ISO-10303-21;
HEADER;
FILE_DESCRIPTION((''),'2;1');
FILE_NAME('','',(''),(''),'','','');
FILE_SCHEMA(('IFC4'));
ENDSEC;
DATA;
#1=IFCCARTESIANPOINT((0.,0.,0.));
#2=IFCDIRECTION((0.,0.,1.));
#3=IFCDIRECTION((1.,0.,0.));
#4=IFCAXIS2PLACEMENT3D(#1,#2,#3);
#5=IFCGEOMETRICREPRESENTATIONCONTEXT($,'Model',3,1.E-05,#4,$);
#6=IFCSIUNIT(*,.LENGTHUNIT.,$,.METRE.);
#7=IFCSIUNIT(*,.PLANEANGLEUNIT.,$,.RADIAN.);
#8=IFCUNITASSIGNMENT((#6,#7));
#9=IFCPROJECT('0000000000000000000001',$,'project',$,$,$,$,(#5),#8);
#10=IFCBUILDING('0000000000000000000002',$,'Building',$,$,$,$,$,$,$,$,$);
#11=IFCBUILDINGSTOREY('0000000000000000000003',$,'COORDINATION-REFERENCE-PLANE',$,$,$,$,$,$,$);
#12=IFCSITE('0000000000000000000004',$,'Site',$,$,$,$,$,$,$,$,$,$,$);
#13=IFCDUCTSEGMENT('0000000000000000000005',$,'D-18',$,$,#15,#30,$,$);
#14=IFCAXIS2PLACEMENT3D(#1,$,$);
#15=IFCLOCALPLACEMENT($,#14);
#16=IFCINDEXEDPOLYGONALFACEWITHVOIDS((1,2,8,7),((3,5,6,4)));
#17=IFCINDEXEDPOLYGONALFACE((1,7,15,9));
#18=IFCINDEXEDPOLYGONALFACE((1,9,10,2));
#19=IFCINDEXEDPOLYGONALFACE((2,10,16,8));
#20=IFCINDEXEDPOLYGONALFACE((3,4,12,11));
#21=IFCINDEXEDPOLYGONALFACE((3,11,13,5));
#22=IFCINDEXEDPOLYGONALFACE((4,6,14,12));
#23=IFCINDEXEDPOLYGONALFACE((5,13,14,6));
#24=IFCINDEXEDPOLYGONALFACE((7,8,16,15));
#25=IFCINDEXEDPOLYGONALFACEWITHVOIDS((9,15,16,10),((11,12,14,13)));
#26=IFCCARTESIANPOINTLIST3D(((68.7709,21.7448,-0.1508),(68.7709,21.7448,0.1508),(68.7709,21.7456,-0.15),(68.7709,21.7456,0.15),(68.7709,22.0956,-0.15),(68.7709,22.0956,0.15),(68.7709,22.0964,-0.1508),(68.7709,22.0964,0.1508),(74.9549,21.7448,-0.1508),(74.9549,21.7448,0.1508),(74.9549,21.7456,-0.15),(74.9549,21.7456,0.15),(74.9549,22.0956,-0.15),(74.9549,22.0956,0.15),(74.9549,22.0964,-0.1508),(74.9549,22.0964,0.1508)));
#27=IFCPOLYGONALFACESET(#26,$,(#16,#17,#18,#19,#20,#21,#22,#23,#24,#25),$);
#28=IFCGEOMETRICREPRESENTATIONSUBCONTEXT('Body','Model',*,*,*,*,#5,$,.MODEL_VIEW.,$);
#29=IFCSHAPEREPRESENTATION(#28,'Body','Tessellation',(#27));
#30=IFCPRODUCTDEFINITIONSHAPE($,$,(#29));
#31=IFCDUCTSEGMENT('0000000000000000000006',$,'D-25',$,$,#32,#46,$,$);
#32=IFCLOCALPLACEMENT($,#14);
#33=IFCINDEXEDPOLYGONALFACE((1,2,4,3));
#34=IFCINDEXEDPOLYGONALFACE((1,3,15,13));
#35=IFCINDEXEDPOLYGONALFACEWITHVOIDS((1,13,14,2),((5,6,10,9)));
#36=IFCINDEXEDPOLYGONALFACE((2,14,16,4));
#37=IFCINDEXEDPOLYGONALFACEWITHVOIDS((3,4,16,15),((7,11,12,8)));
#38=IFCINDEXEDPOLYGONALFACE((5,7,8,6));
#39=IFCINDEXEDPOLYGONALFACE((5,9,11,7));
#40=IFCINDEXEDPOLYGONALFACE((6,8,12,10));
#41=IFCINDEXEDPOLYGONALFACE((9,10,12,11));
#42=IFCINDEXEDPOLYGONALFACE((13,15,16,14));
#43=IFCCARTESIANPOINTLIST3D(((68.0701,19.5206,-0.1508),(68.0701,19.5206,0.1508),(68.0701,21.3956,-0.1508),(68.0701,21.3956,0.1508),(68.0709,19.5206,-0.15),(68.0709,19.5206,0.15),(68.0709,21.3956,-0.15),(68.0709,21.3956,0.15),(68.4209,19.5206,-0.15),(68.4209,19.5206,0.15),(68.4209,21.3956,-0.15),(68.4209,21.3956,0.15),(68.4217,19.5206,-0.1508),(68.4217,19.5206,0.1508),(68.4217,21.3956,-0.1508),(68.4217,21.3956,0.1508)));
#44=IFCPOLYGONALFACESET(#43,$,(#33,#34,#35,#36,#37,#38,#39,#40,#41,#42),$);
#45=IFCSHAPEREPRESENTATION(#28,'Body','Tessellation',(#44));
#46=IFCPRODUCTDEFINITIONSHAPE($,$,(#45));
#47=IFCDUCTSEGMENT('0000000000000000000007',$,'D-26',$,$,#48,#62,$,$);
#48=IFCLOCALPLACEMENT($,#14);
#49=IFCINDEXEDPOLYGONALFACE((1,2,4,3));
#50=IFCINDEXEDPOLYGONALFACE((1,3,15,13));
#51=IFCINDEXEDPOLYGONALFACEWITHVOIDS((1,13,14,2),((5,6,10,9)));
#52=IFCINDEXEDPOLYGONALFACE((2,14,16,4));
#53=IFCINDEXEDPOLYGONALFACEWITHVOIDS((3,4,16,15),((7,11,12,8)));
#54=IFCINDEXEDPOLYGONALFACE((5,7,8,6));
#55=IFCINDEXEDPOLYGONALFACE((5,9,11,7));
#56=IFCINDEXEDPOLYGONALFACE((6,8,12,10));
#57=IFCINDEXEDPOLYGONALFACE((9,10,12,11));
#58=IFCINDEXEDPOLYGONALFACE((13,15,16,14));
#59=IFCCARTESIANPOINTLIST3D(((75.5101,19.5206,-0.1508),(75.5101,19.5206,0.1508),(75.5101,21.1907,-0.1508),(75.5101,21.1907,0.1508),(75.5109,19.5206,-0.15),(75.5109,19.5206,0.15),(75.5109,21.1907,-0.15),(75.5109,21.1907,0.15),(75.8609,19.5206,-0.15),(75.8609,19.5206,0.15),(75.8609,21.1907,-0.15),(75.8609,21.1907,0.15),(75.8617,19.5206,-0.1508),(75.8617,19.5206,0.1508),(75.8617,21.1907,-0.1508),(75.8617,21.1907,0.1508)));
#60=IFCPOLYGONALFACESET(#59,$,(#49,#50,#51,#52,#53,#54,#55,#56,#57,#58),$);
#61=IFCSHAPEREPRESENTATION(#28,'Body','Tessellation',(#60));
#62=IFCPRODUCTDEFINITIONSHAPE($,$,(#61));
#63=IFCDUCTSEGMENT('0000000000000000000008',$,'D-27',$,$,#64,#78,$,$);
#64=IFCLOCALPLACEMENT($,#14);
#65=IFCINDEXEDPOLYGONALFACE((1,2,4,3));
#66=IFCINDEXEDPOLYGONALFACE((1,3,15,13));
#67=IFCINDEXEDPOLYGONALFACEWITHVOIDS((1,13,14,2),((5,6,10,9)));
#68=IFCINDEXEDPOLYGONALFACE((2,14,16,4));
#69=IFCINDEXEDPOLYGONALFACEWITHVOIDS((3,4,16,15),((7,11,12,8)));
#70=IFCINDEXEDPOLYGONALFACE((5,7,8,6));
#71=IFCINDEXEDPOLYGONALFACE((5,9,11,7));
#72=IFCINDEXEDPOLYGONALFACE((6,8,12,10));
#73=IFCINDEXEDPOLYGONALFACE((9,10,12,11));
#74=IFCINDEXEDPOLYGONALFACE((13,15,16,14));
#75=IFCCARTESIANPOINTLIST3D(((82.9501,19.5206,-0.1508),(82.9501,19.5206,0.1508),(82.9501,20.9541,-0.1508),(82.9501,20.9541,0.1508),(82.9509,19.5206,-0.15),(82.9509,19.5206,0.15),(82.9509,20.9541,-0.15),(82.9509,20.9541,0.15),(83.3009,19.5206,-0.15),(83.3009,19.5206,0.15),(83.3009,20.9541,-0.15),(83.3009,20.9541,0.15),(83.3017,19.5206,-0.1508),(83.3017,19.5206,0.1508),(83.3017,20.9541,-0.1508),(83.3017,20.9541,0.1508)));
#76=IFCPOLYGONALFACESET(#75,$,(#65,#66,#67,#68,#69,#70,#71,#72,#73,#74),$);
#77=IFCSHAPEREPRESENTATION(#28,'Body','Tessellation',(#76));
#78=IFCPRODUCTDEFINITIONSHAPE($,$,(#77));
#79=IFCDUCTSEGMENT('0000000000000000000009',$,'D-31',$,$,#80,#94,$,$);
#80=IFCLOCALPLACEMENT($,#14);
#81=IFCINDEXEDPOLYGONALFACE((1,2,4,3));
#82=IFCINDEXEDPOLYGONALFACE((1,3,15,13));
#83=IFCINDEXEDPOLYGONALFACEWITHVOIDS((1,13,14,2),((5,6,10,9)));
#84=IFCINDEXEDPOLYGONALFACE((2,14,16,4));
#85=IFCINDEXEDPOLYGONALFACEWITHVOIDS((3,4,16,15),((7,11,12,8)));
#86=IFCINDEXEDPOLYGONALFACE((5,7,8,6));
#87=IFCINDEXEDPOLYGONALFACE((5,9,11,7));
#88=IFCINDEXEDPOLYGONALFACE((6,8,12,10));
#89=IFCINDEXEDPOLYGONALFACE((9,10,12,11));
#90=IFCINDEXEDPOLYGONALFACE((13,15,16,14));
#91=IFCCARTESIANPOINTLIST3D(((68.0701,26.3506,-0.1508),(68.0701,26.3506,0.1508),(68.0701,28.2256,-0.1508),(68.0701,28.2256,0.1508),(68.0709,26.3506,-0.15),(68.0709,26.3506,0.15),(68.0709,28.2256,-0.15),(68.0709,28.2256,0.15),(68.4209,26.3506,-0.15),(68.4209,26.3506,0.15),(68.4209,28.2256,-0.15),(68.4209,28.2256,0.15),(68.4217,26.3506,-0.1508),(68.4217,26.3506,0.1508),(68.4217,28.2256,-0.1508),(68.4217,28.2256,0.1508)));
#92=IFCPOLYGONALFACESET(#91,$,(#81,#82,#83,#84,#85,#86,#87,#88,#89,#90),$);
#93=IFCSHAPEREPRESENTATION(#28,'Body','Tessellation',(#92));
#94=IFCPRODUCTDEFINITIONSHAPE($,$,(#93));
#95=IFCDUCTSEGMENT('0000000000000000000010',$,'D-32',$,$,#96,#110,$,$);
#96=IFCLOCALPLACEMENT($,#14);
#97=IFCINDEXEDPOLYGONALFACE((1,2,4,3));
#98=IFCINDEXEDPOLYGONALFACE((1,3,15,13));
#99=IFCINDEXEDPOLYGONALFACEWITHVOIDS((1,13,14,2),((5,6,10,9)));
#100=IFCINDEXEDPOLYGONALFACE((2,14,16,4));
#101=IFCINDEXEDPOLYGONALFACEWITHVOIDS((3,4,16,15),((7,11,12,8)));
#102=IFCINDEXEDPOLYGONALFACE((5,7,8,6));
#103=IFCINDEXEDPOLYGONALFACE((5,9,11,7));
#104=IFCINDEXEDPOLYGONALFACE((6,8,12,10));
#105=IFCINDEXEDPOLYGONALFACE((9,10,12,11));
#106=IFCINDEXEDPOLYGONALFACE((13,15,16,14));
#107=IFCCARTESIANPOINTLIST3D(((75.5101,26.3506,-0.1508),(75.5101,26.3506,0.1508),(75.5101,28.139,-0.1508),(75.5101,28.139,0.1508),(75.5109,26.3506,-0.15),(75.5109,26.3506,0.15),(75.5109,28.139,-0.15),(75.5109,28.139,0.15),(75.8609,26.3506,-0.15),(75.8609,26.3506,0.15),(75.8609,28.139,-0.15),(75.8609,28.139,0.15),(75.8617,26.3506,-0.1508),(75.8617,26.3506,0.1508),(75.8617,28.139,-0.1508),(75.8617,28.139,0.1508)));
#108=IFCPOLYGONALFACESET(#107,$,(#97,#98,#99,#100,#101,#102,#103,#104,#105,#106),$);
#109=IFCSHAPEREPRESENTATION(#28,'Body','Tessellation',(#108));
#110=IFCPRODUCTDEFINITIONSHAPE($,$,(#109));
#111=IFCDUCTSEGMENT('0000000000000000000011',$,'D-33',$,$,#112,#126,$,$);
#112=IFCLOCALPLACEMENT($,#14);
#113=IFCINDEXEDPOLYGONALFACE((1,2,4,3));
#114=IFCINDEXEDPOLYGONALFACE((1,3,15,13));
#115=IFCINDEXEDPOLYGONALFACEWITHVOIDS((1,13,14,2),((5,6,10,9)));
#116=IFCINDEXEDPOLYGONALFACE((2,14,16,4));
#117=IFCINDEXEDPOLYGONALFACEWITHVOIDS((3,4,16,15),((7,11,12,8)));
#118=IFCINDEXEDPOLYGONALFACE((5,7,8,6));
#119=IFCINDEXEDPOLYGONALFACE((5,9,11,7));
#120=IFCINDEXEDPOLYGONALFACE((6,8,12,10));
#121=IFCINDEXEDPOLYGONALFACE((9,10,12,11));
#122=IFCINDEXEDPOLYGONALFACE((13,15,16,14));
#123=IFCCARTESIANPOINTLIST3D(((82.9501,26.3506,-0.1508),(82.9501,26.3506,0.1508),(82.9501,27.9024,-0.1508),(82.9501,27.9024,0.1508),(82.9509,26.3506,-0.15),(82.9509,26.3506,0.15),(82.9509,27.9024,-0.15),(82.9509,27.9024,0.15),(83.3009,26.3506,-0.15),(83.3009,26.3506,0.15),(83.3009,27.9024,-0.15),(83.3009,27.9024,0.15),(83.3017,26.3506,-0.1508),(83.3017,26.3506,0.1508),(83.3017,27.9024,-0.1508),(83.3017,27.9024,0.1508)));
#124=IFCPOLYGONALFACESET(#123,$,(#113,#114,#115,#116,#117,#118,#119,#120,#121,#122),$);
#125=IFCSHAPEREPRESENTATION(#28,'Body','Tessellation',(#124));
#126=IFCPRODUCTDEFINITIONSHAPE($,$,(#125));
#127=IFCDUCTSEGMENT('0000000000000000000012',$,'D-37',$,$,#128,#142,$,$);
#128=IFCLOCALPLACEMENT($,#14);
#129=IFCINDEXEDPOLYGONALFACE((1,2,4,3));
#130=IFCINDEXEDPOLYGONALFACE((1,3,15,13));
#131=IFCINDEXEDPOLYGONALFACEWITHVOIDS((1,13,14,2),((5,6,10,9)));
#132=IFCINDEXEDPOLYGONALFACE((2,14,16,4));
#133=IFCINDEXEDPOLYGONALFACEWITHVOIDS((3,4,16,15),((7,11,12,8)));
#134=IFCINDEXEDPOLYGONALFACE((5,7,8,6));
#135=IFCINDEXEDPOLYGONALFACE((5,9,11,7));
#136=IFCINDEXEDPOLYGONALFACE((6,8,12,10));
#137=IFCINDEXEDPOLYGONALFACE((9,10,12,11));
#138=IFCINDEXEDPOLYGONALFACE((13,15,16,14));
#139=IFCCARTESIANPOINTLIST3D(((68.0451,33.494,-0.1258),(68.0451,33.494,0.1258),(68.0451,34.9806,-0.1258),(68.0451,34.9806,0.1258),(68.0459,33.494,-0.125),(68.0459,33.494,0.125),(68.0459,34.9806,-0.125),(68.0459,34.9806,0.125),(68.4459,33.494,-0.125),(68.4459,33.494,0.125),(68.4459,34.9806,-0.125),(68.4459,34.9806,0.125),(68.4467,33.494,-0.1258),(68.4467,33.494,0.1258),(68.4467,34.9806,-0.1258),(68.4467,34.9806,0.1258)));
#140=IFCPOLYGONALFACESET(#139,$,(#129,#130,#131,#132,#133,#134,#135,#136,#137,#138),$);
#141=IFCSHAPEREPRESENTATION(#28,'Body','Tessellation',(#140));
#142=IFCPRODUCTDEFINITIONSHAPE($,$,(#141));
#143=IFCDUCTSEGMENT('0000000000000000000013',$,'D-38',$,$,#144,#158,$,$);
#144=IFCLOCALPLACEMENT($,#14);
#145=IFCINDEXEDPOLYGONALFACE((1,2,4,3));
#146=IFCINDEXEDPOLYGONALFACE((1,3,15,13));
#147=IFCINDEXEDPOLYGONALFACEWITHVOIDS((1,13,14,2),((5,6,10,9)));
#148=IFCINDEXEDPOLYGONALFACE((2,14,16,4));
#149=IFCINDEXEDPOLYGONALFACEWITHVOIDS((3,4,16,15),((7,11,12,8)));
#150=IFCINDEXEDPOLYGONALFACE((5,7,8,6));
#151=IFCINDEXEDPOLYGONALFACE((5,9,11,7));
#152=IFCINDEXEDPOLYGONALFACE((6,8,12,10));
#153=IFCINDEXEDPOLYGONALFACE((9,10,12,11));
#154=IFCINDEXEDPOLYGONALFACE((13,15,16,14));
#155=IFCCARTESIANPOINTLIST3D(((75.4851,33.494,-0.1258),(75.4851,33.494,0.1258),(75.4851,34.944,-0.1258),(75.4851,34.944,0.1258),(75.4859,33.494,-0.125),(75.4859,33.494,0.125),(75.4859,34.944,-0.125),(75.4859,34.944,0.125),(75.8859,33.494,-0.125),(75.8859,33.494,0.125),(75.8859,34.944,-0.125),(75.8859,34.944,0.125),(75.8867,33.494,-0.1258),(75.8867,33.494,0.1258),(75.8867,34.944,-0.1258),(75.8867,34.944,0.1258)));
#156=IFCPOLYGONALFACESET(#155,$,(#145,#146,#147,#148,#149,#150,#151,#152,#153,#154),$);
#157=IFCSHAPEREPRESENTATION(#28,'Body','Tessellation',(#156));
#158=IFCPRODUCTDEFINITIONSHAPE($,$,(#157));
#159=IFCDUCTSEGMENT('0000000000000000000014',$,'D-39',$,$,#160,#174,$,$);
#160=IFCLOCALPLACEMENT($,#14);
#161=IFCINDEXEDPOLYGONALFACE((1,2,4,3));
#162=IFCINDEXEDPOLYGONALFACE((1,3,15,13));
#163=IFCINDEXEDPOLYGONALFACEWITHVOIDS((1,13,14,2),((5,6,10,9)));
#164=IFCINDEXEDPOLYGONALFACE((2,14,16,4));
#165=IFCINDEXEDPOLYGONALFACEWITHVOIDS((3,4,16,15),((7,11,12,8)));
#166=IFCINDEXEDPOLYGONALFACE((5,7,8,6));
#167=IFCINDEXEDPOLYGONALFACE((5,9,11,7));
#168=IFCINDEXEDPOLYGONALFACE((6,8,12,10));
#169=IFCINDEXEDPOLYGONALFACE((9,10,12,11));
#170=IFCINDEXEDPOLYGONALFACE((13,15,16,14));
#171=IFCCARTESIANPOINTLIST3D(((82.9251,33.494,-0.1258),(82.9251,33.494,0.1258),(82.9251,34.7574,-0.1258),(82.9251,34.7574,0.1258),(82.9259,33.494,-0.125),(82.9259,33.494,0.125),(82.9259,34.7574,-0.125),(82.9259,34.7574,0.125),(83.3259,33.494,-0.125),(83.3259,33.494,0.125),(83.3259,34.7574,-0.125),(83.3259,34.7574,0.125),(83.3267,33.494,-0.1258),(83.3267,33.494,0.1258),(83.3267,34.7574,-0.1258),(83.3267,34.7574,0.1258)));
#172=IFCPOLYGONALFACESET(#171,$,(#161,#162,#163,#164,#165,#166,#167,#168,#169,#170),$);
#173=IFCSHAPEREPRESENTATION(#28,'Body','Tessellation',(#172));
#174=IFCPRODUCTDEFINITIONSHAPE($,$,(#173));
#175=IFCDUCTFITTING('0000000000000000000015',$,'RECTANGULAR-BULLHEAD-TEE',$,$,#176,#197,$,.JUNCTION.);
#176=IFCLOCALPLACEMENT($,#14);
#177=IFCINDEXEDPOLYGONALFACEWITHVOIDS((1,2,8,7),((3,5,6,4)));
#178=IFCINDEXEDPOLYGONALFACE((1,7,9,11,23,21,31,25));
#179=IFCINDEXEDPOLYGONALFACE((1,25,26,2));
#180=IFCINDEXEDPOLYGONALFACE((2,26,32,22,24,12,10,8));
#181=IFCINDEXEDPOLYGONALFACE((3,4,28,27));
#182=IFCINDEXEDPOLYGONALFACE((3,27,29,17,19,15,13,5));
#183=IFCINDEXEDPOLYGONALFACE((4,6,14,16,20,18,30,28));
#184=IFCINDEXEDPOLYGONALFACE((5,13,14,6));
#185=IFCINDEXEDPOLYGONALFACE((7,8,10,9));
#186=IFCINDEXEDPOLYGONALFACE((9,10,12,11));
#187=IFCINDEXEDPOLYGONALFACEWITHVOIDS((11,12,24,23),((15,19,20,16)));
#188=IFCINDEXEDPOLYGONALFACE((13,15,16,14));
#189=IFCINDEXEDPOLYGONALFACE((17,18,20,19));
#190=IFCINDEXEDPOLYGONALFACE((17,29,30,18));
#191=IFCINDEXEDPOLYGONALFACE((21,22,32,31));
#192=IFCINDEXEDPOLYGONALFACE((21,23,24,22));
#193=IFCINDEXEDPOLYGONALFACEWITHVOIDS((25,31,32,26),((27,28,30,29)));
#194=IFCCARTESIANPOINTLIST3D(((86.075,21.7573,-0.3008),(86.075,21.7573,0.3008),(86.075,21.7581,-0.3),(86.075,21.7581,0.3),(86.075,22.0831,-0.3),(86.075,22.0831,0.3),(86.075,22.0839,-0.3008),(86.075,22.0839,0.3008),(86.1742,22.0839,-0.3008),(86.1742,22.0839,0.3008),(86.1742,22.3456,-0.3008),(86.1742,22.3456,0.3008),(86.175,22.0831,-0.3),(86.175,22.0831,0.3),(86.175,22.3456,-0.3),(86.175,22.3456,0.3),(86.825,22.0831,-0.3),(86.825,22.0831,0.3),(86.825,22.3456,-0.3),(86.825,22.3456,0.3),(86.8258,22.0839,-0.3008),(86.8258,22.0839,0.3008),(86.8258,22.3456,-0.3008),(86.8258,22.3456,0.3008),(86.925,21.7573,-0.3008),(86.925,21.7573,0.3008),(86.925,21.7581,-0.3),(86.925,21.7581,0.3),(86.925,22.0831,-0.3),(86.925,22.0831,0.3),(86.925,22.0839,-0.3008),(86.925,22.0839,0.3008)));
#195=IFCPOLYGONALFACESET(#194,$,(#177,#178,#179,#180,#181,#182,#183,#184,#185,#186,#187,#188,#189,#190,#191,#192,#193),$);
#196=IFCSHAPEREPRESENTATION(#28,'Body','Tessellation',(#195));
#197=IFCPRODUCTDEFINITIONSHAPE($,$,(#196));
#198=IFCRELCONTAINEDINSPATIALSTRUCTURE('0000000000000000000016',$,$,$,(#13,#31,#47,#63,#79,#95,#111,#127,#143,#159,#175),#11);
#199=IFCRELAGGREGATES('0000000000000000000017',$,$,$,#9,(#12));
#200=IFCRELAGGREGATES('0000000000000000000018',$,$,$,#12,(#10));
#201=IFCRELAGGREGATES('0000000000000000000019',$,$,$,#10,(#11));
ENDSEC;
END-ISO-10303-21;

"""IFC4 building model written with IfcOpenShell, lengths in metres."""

from ifc_helpers import new_model, si_unit, frame, origin, origin_with_axes, place, context, subcontext, project, spatial, rectangle, hollow_rectangle, extrude, boolean, element, save


model = new_model("IFC4")

# Units and contexts
model_context = context("Model", 3, precision=1e-05, world=origin_with_axes())
body_context = subcontext(model_context, "Body", "Model", "MODEL_VIEW")
ifc_project = project(units=[si_unit("LENGTHUNIT", "METRE"), si_unit("PLANEANGLEUNIT", "RADIAN")], contexts=[model_context])

# Site, building, storey
site = spatial("IfcSite", under=ifc_project, Name="Site")
building = spatial("IfcBuilding", under=site, Name="Building")
storey = spatial("IfcBuildingStorey", under=building, Name="COORDINATION-REFERENCE-PLANE")

# Duct segments
duct_segment_1_placement = place(None, frame((68.7709, 21.9206, 0.0), z_axis=(1.0, 0.0, 0.0), x_axis=(0.0, 1.0, 0.0)))
element("IfcDuctSegment", 1, at=duct_segment_1_placement, inside=storey, Name="D-18", context=body_context, shape_type="SweptSolid", body=[
    extrude(hollow_rectangle(XDim=0.3516, YDim=0.3016, WallThickness=0.0008), origin(), (0.0, 0.0, 1.0), 6.1839),
])
duct_segment_2_placement = place(None, frame((68.2459, 19.5206, 0.0), z_axis=(0.0, 1.0, 0.0), x_axis=(1.0, 0.0, 0.0)))
element("IfcDuctSegment", 2, at=duct_segment_2_placement, inside=storey, Name="D-25", context=body_context, shape_type="SweptSolid", body=[
    extrude(hollow_rectangle(XDim=0.3516, YDim=0.3016, WallThickness=0.0008), origin(), (0.0, 0.0, 1.0), 1.875),
])
duct_segment_3_placement = place(None, frame((75.6859, 19.5206, 0.0), z_axis=(0.0, 1.0, 0.0), x_axis=(1.0, 0.0, 0.0)))
element("IfcDuctSegment", 3, at=duct_segment_3_placement, inside=storey, Name="D-26", context=body_context, shape_type="SweptSolid", body=[
    extrude(hollow_rectangle(XDim=0.3516, YDim=0.3016, WallThickness=0.0008), origin(), (0.0, 0.0, 1.0), 1.6701),
])
duct_segment_4_placement = place(None, frame((83.1259, 19.5206, 0.0), z_axis=(0.0, 1.0, 0.0), x_axis=(1.0, 0.0, 0.0)))
element("IfcDuctSegment", 4, at=duct_segment_4_placement, inside=storey, Name="D-27", context=body_context, shape_type="SweptSolid", body=[
    extrude(hollow_rectangle(XDim=0.3516, YDim=0.3016, WallThickness=0.0008), origin(), (0.0, 0.0, 1.0), 1.4335),
])
duct_segment_5_placement = place(None, frame((68.2459, 26.3506, 0.0), z_axis=(0.0, 1.0, 0.0), x_axis=(1.0, 0.0, 0.0)))
element("IfcDuctSegment", 5, at=duct_segment_5_placement, inside=storey, Name="D-31", context=body_context, shape_type="SweptSolid", body=[
    extrude(hollow_rectangle(XDim=0.3516, YDim=0.3016, WallThickness=0.0008), origin(), (0.0, 0.0, 1.0), 1.875),
])
duct_segment_6_placement = place(None, frame((75.6859, 26.3506, 0.0), z_axis=(0.0, 1.0, 0.0), x_axis=(1.0, 0.0, 0.0)))
element("IfcDuctSegment", 6, at=duct_segment_6_placement, inside=storey, Name="D-32", context=body_context, shape_type="SweptSolid", body=[
    extrude(hollow_rectangle(XDim=0.3516, YDim=0.3016, WallThickness=0.0008), origin(), (0.0, 0.0, 1.0), 1.7884),
])
duct_segment_7_placement = place(None, frame((83.1259, 26.3506, 0.0), z_axis=(0.0, 1.0, 0.0), x_axis=(1.0, 0.0, 0.0)))
element("IfcDuctSegment", 7, at=duct_segment_7_placement, inside=storey, Name="D-33", context=body_context, shape_type="SweptSolid", body=[
    extrude(hollow_rectangle(XDim=0.3516, YDim=0.3016, WallThickness=0.0008), origin(), (0.0, 0.0, 1.0), 1.5518),
])
duct_segment_8_placement = place(None, frame((68.2459, 33.494, 0.0), z_axis=(0.0, 1.0, 0.0), x_axis=(1.0, 0.0, 0.0)))
element("IfcDuctSegment", 8, at=duct_segment_8_placement, inside=storey, Name="D-37", context=body_context, shape_type="SweptSolid", body=[
    extrude(hollow_rectangle(XDim=0.4016, YDim=0.2516, WallThickness=0.0008), origin(), (0.0, 0.0, 1.0), 1.4865),
])
duct_segment_9_placement = place(None, frame((75.6859, 33.494, 0.0), z_axis=(0.0, 1.0, 0.0), x_axis=(1.0, 0.0, 0.0)))
element("IfcDuctSegment", 9, at=duct_segment_9_placement, inside=storey, Name="D-38", context=body_context, shape_type="SweptSolid", body=[
    extrude(hollow_rectangle(XDim=0.4016, YDim=0.2516, WallThickness=0.0008), origin(), (0.0, 0.0, 1.0), 1.4499),
])
duct_segment_10_placement = place(None, frame((83.1259, 33.494, 0.0), z_axis=(0.0, 1.0, 0.0), x_axis=(1.0, 0.0, 0.0)))
element("IfcDuctSegment", 10, at=duct_segment_10_placement, inside=storey, Name="D-39", context=body_context, shape_type="SweptSolid", body=[
    extrude(hollow_rectangle(XDim=0.4016, YDim=0.2516, WallThickness=0.0008), origin(), (0.0, 0.0, 1.0), 1.2633),
])

# Duct fitting
duct_fitting_1_placement = place(None, frame((86.5, 21.9206, 0.0), z_axis=(1.0, 0.0, 0.0), x_axis=(0.0, 1.0, 0.0)))
solid_1 = boolean("UNION", extrude(rectangle(XDim=0.325, YDim=0.6), frame((0.0, 0.0, -0.425), z_axis=(0.0, 0.0, 1.0), x_axis=(1.0, 0.0, 0.0)), (0.0, 0.0, 1.0), 0.85), extrude(rectangle(XDim=0.65, YDim=0.6), frame((0.0, 0.0, 0.0), z_axis=(1.0, 0.0, 0.0), x_axis=(0.0, 0.0, -1.0)), (0.0, 0.0, 1.0), 0.425))
element("IfcDuctFitting", 11, at=duct_fitting_1_placement, inside=storey, Name="RECTANGULAR-BULLHEAD-TEE", PredefinedType="JUNCTION", context=body_context, shape_type="CSG", body=[
    boolean("DIFFERENCE", boolean("UNION", extrude(rectangle(XDim=0.3266, YDim=0.6016), frame((0.0, 0.0, -0.425), z_axis=(0.0, 0.0, 1.0), x_axis=(1.0, 0.0, 0.0)), (0.0, 0.0, 1.0), 0.85), extrude(rectangle(XDim=0.6516, YDim=0.6016), frame((0.0, 0.0, 0.0), z_axis=(1.0, 0.0, 0.0), x_axis=(0.0, 0.0, -1.0)), (0.0, 0.0, 1.0), 0.425)), solid_1),
])

save(model, "model.ifc")
